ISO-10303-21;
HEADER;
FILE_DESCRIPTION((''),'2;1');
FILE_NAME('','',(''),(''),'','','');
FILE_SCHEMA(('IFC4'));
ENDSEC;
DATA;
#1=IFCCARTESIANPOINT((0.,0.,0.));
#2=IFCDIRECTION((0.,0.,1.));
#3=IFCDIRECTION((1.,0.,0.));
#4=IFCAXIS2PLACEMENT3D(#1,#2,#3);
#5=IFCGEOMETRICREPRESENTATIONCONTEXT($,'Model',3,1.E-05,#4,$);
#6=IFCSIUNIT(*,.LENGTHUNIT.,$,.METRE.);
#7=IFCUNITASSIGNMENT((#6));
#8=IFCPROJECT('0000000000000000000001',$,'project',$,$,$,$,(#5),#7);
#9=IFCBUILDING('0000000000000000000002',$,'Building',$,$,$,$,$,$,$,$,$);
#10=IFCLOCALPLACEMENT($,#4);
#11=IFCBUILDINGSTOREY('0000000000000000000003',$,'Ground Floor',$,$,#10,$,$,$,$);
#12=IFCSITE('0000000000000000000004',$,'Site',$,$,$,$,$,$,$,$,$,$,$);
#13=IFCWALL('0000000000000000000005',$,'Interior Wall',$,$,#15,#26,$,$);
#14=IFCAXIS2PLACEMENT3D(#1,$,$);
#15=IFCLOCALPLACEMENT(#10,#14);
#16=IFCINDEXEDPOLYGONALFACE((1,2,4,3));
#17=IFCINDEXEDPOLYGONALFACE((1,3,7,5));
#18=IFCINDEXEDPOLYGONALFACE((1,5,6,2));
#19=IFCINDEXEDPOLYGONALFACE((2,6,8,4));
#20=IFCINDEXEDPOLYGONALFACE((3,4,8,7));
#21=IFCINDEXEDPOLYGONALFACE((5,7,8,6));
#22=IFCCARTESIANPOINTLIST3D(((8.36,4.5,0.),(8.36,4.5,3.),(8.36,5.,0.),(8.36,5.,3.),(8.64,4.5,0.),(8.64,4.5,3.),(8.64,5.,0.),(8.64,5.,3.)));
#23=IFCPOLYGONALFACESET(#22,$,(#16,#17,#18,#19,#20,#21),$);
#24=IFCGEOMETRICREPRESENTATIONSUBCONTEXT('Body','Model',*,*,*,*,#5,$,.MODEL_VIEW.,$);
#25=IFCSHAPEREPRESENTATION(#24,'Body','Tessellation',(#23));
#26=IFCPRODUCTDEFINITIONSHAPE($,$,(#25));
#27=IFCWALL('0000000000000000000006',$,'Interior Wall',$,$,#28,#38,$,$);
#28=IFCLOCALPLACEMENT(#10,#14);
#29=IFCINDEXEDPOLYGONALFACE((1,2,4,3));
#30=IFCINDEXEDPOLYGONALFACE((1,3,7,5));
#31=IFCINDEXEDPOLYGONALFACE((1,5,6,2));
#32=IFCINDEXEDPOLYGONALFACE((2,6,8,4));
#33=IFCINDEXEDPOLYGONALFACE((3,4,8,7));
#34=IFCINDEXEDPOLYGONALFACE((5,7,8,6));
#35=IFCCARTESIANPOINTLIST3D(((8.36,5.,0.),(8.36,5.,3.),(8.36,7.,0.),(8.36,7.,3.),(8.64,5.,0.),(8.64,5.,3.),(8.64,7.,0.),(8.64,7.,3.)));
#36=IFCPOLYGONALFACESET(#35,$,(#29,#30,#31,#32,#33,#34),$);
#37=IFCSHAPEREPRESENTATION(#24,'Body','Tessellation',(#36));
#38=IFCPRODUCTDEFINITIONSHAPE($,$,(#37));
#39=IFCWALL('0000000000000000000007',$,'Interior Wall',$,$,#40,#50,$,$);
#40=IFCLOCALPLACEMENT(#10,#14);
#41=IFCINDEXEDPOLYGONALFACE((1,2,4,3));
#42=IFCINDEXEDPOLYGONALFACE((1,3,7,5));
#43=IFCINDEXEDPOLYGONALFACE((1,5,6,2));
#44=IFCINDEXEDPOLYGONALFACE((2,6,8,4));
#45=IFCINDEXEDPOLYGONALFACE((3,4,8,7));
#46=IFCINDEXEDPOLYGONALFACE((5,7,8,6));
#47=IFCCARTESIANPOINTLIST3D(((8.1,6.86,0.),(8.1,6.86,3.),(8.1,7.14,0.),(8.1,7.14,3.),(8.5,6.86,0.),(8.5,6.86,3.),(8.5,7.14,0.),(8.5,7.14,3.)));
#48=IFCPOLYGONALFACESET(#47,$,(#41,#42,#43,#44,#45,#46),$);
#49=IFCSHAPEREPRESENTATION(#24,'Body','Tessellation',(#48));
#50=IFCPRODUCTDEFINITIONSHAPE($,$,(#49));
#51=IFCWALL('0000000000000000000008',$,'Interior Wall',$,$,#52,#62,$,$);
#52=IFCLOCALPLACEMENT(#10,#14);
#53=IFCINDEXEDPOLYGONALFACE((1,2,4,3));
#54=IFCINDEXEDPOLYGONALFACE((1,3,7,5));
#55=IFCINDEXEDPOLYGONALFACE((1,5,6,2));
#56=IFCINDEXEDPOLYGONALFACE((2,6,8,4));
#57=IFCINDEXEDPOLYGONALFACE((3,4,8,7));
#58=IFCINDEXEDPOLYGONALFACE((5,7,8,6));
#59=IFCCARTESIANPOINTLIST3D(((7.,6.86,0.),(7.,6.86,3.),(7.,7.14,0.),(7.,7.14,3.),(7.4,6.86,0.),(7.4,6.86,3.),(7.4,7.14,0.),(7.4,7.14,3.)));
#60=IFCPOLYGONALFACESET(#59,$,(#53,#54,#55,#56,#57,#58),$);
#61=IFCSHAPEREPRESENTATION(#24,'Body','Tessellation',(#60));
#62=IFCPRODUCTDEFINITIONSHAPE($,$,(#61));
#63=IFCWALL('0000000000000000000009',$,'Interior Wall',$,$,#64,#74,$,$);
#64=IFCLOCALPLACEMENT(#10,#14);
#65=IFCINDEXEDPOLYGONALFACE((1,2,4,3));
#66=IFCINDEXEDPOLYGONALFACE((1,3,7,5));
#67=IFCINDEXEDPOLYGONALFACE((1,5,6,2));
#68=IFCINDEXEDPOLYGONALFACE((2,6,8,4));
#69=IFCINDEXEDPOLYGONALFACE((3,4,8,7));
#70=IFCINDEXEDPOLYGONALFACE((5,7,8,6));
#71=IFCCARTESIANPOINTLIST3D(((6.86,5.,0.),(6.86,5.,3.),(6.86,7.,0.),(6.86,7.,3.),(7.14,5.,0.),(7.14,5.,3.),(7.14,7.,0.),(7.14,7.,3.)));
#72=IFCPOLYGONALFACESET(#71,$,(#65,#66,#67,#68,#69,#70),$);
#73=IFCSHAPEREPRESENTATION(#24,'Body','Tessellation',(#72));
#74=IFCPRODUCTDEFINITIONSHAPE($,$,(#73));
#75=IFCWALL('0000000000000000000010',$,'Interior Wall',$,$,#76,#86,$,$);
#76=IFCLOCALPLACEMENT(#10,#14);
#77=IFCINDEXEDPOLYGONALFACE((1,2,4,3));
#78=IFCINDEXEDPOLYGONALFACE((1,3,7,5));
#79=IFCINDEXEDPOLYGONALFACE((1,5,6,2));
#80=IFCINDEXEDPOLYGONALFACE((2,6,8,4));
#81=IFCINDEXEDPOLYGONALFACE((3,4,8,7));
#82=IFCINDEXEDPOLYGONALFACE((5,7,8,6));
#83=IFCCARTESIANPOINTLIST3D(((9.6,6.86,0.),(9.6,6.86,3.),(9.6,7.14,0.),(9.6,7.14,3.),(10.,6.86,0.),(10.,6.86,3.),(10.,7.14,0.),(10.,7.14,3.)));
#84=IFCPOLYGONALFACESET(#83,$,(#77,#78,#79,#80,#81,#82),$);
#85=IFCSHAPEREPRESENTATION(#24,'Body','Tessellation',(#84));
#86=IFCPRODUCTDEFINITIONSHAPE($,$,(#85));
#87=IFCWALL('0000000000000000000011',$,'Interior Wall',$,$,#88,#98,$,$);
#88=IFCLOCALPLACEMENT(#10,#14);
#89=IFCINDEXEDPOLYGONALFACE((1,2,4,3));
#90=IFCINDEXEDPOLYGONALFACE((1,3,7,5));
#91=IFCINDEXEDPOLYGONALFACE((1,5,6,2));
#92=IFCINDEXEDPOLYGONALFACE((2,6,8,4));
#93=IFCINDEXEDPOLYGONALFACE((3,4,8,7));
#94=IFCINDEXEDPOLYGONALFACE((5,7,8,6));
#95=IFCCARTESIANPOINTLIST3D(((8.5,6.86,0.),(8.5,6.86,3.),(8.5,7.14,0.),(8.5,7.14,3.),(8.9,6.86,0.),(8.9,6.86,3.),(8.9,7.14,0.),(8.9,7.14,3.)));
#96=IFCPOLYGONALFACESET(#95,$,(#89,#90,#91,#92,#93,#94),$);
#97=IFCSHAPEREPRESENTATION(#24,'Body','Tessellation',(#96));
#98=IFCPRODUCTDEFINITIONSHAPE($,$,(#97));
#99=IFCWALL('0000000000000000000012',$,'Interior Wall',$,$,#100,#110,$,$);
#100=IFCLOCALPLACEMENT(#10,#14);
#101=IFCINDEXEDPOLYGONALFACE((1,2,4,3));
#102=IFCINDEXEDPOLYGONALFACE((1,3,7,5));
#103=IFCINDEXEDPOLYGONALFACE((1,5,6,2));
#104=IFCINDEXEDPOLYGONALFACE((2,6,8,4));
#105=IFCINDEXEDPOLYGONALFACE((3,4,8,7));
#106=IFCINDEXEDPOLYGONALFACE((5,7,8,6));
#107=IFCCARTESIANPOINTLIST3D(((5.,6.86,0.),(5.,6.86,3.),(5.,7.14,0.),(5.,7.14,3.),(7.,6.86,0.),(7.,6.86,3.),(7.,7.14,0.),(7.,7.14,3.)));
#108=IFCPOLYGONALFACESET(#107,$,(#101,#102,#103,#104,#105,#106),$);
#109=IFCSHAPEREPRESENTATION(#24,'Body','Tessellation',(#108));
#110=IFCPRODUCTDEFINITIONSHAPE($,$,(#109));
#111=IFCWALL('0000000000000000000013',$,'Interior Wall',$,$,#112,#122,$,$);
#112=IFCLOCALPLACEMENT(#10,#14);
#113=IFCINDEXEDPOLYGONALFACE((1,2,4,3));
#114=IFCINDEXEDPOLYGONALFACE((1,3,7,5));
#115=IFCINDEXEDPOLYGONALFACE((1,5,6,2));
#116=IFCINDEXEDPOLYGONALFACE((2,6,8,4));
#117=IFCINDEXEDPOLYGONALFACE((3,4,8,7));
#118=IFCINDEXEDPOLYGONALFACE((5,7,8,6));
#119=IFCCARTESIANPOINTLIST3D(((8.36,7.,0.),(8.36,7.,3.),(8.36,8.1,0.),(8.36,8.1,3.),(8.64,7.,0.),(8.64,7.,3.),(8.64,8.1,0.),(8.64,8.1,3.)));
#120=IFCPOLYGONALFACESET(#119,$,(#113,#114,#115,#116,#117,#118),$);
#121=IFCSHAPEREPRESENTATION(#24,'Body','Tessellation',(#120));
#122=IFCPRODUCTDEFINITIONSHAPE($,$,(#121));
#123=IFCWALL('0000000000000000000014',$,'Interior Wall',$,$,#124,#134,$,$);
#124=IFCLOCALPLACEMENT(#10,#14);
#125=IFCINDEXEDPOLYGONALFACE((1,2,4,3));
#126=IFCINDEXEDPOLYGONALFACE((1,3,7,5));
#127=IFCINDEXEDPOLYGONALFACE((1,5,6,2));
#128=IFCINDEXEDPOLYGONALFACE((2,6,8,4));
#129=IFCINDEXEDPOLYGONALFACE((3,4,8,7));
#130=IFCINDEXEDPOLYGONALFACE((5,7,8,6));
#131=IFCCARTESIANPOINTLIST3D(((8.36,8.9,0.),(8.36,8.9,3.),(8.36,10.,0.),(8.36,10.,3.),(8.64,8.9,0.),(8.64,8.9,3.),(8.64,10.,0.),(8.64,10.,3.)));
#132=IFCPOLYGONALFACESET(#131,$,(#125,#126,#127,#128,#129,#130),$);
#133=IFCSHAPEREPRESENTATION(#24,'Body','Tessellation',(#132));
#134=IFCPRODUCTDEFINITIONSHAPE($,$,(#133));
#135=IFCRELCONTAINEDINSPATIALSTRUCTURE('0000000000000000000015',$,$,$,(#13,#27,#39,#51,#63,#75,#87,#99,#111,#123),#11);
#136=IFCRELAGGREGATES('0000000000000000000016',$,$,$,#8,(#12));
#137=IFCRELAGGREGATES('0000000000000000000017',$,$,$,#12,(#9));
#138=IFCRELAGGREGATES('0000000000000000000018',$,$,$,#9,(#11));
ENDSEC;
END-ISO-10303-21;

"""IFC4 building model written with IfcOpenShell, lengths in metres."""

from ifc_helpers import new_model, si_unit, frame, origin_with_axes, place, context, subcontext, project, spatial, indexed_curve, outline, extrude, element, save


model = new_model("IFC4")

# Units and contexts
model_context = context("Model", 3, precision=1e-05, world=origin_with_axes())
body_context = subcontext(model_context, "Body", "Model", "MODEL_VIEW")
ifc_project = project(units=[si_unit("LENGTHUNIT", "METRE")], contexts=[model_context])

# Site, building, storey
site = spatial("IfcSite", under=ifc_project, Name="Site")
building = spatial("IfcBuilding", under=site, Name="Building")
storey_placement = place(None, origin_with_axes())
storey = spatial("IfcBuildingStorey", under=building, at=storey_placement, Name="Ground Floor")

# Walls
wall_1_placement = place(storey_placement, frame((8.5, 5.0, 0.0), z_axis=(0.0, 0.0, 1.0), x_axis=(0.0, -1.0, 0.0)))
element("IfcWall", 1, at=wall_1_placement, inside=storey, Name="Interior Wall", context=body_context, shape_type="SweptSolid", body=[
    extrude(outline(indexed_curve([(0.0, 0.0), (0.0, 0.28), (0.5, 0.28), (0.5, 0.0), (0.0, 0.0)], self_intersect=False)), frame((0.0, -0.14, 0.0), z_axis=(0.0, 0.0, 1.0), x_axis=(1.0, 0.0, 0.0)), (0.0, 0.0, 1.0), 3.0),
])
wall_2_placement = place(storey_placement, frame((8.5, 5.0, 0.0), z_axis=(0.0, 0.0, 1.0), x_axis=(0.0, 1.0, 0.0)))
element("IfcWall", 2, at=wall_2_placement, inside=storey, Name="Interior Wall", context=body_context, shape_type="SweptSolid", body=[
    extrude(outline(indexed_curve([(0.0, 0.0), (0.0, 0.28), (2.0, 0.28), (2.0, 0.0), (0.0, 0.0)], self_intersect=False)), frame((0.0, -0.14, 0.0), z_axis=(0.0, 0.0, 1.0), x_axis=(1.0, 0.0, 0.0)), (0.0, 0.0, 1.0), 3.0),
])
for number, where, z_axis, x_axis, name in (
    (3, (8.5, 7.0, 0.0), (0.0, 0.0, 1.0), (-1.0, 0.0, 0.0), "Interior Wall"),
    (4, (7.4, 7.0, 0.0), (0.0, 0.0, 1.0), (-1.0, 0.0, 0.0), "Interior Wall"),
):
    element("IfcWall", number, at=place(storey_placement, frame(where, z_axis=z_axis, x_axis=x_axis)), inside=storey, Name=name, context=body_context, shape_type="SweptSolid", body=[
        extrude(outline(indexed_curve([(0.0, 0.0), (0.0, 0.28), (0.4, 0.28), (0.4, 0.0), (0.0, 0.0)], self_intersect=False)), frame((0.0, -0.14, 0.0), z_axis=(0.0, 0.0, 1.0), x_axis=(1.0, 0.0, 0.0)), (0.0, 0.0, 1.0), 3.0),
    ])
wall_3_placement = place(storey_placement, frame((7.0, 7.0, 0.0), z_axis=(0.0, 0.0, 1.0), x_axis=(0.0, -1.0, 0.0)))
element("IfcWall", 5, at=wall_3_placement, inside=storey, Name="Interior Wall", context=body_context, shape_type="SweptSolid", body=[
    extrude(outline(indexed_curve([(0.0, 0.0), (0.0, 0.28), (2.0, 0.28), (2.0, 0.0), (0.0, 0.0)], self_intersect=False)), frame((0.0, -0.14, 0.0), z_axis=(0.0, 0.0, 1.0), x_axis=(1.0, 0.0, 0.0)), (0.0, 0.0, 1.0), 3.0),
])
for number, where, z_axis, x_axis, name in (
    (6, (10.0, 7.0, 0.0), (0.0, 0.0, 1.0), (-1.0, 0.0, 0.0), "Interior Wall"),
    (7, (8.9, 7.0, 0.0), (0.0, 0.0, 1.0), (-1.0, 0.0, 0.0), "Interior Wall"),
):
    element("IfcWall", number, at=place(storey_placement, frame(where, z_axis=z_axis, x_axis=x_axis)), inside=storey, Name=name, context=body_context, shape_type="SweptSolid", body=[
        extrude(outline(indexed_curve([(0.0, 0.0), (0.0, 0.28), (0.4, 0.28), (0.4, 0.0), (0.0, 0.0)], self_intersect=False)), frame((0.0, -0.14, 0.0), z_axis=(0.0, 0.0, 1.0), x_axis=(1.0, 0.0, 0.0)), (0.0, 0.0, 1.0), 3.0),
    ])
wall_4_placement = place(storey_placement, frame((7.0, 7.0, 0.0), z_axis=(0.0, 0.0, 1.0), x_axis=(-1.0, 0.0, 0.0)))
element("IfcWall", 8, at=wall_4_placement, inside=storey, Name="Interior Wall", context=body_context, shape_type="SweptSolid", body=[
    extrude(outline(indexed_curve([(0.0, 0.0), (0.0, 0.28), (2.0, 0.28), (2.0, 0.0), (0.0, 0.0)], self_intersect=False)), frame((0.0, -0.14, 0.0), z_axis=(0.0, 0.0, 1.0), x_axis=(1.0, 0.0, 0.0)), (0.0, 0.0, 1.0), 3.0),
])
for number, where, z_axis, x_axis, name in (
    (9, (8.5, 7.0, 0.0), (0.0, 0.0, 1.0), (0.0, 1.0, 0.0), "Interior Wall"),
    (10, (8.5, 8.9, 0.0), (0.0, 0.0, 1.0), (0.0, 1.0, 0.0), "Interior Wall"),
):
    element("IfcWall", number, at=place(storey_placement, frame(where, z_axis=z_axis, x_axis=x_axis)), inside=storey, Name=name, context=body_context, shape_type="SweptSolid", body=[
        extrude(outline(indexed_curve([(0.0, 0.0), (0.0, 0.28), (1.1, 0.28), (1.1, 0.0), (0.0, 0.0)], self_intersect=False)), frame((0.0, -0.14, 0.0), z_axis=(0.0, 0.0, 1.0), x_axis=(1.0, 0.0, 0.0)), (0.0, 0.0, 1.0), 3.0),
    ])

save(model, "model.ifc")
